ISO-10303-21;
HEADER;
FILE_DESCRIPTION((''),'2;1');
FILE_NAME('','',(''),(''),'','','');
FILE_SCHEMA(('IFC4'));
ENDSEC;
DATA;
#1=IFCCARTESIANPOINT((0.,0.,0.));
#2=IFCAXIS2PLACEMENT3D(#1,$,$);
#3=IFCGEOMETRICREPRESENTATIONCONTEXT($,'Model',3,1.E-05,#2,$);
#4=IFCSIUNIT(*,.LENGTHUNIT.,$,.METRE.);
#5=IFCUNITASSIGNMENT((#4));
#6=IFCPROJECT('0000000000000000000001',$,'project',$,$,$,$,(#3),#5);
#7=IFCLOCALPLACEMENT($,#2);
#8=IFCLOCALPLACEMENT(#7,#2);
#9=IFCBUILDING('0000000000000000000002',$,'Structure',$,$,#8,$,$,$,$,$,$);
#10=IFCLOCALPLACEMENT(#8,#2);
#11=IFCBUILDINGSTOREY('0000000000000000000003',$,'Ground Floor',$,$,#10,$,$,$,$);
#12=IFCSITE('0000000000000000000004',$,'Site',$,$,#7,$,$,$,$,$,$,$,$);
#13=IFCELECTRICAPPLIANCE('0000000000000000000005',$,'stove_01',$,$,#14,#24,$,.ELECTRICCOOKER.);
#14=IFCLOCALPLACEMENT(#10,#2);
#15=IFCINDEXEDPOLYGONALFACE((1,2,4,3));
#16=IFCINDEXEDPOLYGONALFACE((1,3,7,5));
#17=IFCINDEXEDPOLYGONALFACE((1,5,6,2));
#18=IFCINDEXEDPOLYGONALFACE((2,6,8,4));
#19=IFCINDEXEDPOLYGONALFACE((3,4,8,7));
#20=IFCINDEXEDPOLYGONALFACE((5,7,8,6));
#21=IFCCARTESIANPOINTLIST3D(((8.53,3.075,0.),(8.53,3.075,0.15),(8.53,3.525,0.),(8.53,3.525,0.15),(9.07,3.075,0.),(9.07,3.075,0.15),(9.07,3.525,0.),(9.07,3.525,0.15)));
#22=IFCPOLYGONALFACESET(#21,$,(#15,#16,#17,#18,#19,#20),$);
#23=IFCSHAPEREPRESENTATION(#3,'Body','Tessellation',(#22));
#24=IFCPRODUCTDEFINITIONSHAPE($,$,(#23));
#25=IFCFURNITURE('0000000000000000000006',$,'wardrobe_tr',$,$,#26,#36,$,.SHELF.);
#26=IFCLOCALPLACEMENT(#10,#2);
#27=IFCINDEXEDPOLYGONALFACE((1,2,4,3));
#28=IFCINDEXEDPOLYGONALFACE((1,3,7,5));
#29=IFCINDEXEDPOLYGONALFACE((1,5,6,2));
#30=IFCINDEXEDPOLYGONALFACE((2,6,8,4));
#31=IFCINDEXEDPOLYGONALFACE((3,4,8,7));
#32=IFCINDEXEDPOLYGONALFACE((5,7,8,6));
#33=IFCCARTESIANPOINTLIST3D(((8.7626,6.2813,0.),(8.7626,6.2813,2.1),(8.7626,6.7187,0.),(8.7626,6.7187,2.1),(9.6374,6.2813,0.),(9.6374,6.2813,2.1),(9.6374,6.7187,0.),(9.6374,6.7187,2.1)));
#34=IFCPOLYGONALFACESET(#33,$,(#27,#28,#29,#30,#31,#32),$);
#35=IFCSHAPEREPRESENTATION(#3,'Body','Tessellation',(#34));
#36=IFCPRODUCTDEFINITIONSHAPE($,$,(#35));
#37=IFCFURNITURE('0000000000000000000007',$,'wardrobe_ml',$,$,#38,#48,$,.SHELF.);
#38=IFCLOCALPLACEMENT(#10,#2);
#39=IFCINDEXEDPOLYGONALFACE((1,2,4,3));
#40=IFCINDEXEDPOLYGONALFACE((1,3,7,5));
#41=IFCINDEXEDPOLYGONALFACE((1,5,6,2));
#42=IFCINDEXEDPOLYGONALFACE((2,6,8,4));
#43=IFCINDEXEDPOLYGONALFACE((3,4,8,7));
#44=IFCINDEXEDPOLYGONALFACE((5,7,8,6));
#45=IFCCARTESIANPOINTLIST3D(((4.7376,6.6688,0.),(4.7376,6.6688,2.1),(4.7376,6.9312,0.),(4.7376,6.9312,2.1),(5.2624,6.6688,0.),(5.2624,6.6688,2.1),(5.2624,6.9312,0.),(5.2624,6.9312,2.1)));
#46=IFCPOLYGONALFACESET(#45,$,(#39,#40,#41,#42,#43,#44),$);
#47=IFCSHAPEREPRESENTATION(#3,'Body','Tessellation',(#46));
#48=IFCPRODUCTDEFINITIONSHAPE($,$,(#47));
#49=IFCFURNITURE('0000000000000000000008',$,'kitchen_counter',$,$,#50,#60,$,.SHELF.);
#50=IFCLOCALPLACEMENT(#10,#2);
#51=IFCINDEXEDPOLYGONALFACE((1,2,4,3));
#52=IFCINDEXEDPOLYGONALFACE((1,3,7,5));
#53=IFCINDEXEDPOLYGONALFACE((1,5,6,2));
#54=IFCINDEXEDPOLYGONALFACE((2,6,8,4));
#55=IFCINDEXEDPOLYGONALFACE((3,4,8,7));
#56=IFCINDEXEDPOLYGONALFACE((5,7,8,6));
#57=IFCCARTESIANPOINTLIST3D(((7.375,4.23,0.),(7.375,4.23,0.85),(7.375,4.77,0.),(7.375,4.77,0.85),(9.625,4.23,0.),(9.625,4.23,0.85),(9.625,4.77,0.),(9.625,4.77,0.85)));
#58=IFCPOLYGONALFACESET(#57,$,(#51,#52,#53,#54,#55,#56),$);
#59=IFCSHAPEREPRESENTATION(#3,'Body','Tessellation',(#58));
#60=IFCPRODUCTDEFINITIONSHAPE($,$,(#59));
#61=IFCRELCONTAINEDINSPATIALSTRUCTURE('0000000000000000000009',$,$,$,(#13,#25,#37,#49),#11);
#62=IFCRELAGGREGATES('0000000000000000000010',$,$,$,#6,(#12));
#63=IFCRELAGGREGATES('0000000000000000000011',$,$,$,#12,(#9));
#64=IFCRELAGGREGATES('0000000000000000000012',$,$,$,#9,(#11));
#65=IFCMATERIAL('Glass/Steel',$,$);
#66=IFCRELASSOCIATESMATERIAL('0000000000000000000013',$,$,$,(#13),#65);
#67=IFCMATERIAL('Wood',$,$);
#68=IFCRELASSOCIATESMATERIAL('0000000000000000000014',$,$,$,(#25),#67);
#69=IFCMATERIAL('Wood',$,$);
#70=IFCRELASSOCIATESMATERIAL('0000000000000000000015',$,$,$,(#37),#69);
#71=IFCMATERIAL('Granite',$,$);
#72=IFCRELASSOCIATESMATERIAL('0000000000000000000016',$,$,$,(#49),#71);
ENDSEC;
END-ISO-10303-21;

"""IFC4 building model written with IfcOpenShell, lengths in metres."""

from ifc_helpers import new_model, si_unit, frame, origin, place, context, project, spatial, polyline, outline, extrude, material, element, save


model = new_model("IFC4")

# Units and contexts
model_context = context("Model", 3, precision=1e-05, world=origin())
ifc_project = project(units=[si_unit("LENGTHUNIT", "METRE")], contexts=[model_context])

# Site, building, storey
site_placement = place(None, origin())
site = spatial("IfcSite", under=ifc_project, at=site_placement, Name="Site")
building_placement = place(site_placement, origin())
building = spatial("IfcBuilding", under=site, at=building_placement, Name="Structure")
storey_placement = place(building_placement, origin())
storey = spatial("IfcBuildingStorey", under=building, at=storey_placement, Name="Ground Floor")

# Electric appliance
ifc_material_1 = material(Name="Glass/Steel")
electric_appliance_placement = place(storey_placement, frame((8.8, 3.3, 0.0)))
element("IfcElectricAppliance", 1, at=electric_appliance_placement, inside=storey, material=ifc_material_1, Name="stove_01", PredefinedType="ELECTRICCOOKER", context=model_context, shape_type="SweptSolid", body=[
    extrude(outline(polyline([(-0.27, -0.225), (0.27, -0.225), (0.27, 0.225), (-0.27, 0.225), (-0.27, -0.225)])), origin(), (0.0, 0.0, 1.0), 0.15),
])

# Furniture
ifc_material_2 = material(Name="Wood")
furniture_1_placement = place(storey_placement, frame((9.2, 6.5, 0.0)))
element("IfcFurniture", 2, at=furniture_1_placement, inside=storey, material=ifc_material_2, Name="wardrobe_tr", PredefinedType="SHELF", context=model_context, shape_type="SweptSolid", body=[
    extrude(outline(polyline([(-0.4374, -0.2187), (0.4374, -0.2187), (0.4374, 0.2187), (-0.4374, 0.2187), (-0.4374, -0.2187)])), origin(), (0.0, 0.0, 1.0), 2.1),
])
ifc_material_3 = material(Name="Wood")
furniture_2_placement = place(storey_placement, frame((5.0, 6.8, 0.0)))
element("IfcFurniture", 3, at=furniture_2_placement, inside=storey, material=ifc_material_3, Name="wardrobe_ml", PredefinedType="SHELF", context=model_context, shape_type="SweptSolid", body=[
    extrude(outline(polyline([(-0.2624, -0.1312), (0.2624, -0.1312), (0.2624, 0.1312), (-0.2624, 0.1312), (-0.2624, -0.1312)])), origin(), (0.0, 0.0, 1.0), 2.1),
])
ifc_material_4 = material(Name="Granite")
furniture_3_placement = place(storey_placement, frame((8.5, 4.5, 0.0)))
element("IfcFurniture", 4, at=furniture_3_placement, inside=storey, material=ifc_material_4, Name="kitchen_counter", PredefinedType="SHELF", context=model_context, shape_type="SweptSolid", body=[
    extrude(outline(polyline([(-1.125, -0.27), (1.125, -0.27), (1.125, 0.27), (-1.125, 0.27), (-1.125, -0.27)])), origin(), (0.0, 0.0, 1.0), 0.85),
])

save(model, "model.ifc")
